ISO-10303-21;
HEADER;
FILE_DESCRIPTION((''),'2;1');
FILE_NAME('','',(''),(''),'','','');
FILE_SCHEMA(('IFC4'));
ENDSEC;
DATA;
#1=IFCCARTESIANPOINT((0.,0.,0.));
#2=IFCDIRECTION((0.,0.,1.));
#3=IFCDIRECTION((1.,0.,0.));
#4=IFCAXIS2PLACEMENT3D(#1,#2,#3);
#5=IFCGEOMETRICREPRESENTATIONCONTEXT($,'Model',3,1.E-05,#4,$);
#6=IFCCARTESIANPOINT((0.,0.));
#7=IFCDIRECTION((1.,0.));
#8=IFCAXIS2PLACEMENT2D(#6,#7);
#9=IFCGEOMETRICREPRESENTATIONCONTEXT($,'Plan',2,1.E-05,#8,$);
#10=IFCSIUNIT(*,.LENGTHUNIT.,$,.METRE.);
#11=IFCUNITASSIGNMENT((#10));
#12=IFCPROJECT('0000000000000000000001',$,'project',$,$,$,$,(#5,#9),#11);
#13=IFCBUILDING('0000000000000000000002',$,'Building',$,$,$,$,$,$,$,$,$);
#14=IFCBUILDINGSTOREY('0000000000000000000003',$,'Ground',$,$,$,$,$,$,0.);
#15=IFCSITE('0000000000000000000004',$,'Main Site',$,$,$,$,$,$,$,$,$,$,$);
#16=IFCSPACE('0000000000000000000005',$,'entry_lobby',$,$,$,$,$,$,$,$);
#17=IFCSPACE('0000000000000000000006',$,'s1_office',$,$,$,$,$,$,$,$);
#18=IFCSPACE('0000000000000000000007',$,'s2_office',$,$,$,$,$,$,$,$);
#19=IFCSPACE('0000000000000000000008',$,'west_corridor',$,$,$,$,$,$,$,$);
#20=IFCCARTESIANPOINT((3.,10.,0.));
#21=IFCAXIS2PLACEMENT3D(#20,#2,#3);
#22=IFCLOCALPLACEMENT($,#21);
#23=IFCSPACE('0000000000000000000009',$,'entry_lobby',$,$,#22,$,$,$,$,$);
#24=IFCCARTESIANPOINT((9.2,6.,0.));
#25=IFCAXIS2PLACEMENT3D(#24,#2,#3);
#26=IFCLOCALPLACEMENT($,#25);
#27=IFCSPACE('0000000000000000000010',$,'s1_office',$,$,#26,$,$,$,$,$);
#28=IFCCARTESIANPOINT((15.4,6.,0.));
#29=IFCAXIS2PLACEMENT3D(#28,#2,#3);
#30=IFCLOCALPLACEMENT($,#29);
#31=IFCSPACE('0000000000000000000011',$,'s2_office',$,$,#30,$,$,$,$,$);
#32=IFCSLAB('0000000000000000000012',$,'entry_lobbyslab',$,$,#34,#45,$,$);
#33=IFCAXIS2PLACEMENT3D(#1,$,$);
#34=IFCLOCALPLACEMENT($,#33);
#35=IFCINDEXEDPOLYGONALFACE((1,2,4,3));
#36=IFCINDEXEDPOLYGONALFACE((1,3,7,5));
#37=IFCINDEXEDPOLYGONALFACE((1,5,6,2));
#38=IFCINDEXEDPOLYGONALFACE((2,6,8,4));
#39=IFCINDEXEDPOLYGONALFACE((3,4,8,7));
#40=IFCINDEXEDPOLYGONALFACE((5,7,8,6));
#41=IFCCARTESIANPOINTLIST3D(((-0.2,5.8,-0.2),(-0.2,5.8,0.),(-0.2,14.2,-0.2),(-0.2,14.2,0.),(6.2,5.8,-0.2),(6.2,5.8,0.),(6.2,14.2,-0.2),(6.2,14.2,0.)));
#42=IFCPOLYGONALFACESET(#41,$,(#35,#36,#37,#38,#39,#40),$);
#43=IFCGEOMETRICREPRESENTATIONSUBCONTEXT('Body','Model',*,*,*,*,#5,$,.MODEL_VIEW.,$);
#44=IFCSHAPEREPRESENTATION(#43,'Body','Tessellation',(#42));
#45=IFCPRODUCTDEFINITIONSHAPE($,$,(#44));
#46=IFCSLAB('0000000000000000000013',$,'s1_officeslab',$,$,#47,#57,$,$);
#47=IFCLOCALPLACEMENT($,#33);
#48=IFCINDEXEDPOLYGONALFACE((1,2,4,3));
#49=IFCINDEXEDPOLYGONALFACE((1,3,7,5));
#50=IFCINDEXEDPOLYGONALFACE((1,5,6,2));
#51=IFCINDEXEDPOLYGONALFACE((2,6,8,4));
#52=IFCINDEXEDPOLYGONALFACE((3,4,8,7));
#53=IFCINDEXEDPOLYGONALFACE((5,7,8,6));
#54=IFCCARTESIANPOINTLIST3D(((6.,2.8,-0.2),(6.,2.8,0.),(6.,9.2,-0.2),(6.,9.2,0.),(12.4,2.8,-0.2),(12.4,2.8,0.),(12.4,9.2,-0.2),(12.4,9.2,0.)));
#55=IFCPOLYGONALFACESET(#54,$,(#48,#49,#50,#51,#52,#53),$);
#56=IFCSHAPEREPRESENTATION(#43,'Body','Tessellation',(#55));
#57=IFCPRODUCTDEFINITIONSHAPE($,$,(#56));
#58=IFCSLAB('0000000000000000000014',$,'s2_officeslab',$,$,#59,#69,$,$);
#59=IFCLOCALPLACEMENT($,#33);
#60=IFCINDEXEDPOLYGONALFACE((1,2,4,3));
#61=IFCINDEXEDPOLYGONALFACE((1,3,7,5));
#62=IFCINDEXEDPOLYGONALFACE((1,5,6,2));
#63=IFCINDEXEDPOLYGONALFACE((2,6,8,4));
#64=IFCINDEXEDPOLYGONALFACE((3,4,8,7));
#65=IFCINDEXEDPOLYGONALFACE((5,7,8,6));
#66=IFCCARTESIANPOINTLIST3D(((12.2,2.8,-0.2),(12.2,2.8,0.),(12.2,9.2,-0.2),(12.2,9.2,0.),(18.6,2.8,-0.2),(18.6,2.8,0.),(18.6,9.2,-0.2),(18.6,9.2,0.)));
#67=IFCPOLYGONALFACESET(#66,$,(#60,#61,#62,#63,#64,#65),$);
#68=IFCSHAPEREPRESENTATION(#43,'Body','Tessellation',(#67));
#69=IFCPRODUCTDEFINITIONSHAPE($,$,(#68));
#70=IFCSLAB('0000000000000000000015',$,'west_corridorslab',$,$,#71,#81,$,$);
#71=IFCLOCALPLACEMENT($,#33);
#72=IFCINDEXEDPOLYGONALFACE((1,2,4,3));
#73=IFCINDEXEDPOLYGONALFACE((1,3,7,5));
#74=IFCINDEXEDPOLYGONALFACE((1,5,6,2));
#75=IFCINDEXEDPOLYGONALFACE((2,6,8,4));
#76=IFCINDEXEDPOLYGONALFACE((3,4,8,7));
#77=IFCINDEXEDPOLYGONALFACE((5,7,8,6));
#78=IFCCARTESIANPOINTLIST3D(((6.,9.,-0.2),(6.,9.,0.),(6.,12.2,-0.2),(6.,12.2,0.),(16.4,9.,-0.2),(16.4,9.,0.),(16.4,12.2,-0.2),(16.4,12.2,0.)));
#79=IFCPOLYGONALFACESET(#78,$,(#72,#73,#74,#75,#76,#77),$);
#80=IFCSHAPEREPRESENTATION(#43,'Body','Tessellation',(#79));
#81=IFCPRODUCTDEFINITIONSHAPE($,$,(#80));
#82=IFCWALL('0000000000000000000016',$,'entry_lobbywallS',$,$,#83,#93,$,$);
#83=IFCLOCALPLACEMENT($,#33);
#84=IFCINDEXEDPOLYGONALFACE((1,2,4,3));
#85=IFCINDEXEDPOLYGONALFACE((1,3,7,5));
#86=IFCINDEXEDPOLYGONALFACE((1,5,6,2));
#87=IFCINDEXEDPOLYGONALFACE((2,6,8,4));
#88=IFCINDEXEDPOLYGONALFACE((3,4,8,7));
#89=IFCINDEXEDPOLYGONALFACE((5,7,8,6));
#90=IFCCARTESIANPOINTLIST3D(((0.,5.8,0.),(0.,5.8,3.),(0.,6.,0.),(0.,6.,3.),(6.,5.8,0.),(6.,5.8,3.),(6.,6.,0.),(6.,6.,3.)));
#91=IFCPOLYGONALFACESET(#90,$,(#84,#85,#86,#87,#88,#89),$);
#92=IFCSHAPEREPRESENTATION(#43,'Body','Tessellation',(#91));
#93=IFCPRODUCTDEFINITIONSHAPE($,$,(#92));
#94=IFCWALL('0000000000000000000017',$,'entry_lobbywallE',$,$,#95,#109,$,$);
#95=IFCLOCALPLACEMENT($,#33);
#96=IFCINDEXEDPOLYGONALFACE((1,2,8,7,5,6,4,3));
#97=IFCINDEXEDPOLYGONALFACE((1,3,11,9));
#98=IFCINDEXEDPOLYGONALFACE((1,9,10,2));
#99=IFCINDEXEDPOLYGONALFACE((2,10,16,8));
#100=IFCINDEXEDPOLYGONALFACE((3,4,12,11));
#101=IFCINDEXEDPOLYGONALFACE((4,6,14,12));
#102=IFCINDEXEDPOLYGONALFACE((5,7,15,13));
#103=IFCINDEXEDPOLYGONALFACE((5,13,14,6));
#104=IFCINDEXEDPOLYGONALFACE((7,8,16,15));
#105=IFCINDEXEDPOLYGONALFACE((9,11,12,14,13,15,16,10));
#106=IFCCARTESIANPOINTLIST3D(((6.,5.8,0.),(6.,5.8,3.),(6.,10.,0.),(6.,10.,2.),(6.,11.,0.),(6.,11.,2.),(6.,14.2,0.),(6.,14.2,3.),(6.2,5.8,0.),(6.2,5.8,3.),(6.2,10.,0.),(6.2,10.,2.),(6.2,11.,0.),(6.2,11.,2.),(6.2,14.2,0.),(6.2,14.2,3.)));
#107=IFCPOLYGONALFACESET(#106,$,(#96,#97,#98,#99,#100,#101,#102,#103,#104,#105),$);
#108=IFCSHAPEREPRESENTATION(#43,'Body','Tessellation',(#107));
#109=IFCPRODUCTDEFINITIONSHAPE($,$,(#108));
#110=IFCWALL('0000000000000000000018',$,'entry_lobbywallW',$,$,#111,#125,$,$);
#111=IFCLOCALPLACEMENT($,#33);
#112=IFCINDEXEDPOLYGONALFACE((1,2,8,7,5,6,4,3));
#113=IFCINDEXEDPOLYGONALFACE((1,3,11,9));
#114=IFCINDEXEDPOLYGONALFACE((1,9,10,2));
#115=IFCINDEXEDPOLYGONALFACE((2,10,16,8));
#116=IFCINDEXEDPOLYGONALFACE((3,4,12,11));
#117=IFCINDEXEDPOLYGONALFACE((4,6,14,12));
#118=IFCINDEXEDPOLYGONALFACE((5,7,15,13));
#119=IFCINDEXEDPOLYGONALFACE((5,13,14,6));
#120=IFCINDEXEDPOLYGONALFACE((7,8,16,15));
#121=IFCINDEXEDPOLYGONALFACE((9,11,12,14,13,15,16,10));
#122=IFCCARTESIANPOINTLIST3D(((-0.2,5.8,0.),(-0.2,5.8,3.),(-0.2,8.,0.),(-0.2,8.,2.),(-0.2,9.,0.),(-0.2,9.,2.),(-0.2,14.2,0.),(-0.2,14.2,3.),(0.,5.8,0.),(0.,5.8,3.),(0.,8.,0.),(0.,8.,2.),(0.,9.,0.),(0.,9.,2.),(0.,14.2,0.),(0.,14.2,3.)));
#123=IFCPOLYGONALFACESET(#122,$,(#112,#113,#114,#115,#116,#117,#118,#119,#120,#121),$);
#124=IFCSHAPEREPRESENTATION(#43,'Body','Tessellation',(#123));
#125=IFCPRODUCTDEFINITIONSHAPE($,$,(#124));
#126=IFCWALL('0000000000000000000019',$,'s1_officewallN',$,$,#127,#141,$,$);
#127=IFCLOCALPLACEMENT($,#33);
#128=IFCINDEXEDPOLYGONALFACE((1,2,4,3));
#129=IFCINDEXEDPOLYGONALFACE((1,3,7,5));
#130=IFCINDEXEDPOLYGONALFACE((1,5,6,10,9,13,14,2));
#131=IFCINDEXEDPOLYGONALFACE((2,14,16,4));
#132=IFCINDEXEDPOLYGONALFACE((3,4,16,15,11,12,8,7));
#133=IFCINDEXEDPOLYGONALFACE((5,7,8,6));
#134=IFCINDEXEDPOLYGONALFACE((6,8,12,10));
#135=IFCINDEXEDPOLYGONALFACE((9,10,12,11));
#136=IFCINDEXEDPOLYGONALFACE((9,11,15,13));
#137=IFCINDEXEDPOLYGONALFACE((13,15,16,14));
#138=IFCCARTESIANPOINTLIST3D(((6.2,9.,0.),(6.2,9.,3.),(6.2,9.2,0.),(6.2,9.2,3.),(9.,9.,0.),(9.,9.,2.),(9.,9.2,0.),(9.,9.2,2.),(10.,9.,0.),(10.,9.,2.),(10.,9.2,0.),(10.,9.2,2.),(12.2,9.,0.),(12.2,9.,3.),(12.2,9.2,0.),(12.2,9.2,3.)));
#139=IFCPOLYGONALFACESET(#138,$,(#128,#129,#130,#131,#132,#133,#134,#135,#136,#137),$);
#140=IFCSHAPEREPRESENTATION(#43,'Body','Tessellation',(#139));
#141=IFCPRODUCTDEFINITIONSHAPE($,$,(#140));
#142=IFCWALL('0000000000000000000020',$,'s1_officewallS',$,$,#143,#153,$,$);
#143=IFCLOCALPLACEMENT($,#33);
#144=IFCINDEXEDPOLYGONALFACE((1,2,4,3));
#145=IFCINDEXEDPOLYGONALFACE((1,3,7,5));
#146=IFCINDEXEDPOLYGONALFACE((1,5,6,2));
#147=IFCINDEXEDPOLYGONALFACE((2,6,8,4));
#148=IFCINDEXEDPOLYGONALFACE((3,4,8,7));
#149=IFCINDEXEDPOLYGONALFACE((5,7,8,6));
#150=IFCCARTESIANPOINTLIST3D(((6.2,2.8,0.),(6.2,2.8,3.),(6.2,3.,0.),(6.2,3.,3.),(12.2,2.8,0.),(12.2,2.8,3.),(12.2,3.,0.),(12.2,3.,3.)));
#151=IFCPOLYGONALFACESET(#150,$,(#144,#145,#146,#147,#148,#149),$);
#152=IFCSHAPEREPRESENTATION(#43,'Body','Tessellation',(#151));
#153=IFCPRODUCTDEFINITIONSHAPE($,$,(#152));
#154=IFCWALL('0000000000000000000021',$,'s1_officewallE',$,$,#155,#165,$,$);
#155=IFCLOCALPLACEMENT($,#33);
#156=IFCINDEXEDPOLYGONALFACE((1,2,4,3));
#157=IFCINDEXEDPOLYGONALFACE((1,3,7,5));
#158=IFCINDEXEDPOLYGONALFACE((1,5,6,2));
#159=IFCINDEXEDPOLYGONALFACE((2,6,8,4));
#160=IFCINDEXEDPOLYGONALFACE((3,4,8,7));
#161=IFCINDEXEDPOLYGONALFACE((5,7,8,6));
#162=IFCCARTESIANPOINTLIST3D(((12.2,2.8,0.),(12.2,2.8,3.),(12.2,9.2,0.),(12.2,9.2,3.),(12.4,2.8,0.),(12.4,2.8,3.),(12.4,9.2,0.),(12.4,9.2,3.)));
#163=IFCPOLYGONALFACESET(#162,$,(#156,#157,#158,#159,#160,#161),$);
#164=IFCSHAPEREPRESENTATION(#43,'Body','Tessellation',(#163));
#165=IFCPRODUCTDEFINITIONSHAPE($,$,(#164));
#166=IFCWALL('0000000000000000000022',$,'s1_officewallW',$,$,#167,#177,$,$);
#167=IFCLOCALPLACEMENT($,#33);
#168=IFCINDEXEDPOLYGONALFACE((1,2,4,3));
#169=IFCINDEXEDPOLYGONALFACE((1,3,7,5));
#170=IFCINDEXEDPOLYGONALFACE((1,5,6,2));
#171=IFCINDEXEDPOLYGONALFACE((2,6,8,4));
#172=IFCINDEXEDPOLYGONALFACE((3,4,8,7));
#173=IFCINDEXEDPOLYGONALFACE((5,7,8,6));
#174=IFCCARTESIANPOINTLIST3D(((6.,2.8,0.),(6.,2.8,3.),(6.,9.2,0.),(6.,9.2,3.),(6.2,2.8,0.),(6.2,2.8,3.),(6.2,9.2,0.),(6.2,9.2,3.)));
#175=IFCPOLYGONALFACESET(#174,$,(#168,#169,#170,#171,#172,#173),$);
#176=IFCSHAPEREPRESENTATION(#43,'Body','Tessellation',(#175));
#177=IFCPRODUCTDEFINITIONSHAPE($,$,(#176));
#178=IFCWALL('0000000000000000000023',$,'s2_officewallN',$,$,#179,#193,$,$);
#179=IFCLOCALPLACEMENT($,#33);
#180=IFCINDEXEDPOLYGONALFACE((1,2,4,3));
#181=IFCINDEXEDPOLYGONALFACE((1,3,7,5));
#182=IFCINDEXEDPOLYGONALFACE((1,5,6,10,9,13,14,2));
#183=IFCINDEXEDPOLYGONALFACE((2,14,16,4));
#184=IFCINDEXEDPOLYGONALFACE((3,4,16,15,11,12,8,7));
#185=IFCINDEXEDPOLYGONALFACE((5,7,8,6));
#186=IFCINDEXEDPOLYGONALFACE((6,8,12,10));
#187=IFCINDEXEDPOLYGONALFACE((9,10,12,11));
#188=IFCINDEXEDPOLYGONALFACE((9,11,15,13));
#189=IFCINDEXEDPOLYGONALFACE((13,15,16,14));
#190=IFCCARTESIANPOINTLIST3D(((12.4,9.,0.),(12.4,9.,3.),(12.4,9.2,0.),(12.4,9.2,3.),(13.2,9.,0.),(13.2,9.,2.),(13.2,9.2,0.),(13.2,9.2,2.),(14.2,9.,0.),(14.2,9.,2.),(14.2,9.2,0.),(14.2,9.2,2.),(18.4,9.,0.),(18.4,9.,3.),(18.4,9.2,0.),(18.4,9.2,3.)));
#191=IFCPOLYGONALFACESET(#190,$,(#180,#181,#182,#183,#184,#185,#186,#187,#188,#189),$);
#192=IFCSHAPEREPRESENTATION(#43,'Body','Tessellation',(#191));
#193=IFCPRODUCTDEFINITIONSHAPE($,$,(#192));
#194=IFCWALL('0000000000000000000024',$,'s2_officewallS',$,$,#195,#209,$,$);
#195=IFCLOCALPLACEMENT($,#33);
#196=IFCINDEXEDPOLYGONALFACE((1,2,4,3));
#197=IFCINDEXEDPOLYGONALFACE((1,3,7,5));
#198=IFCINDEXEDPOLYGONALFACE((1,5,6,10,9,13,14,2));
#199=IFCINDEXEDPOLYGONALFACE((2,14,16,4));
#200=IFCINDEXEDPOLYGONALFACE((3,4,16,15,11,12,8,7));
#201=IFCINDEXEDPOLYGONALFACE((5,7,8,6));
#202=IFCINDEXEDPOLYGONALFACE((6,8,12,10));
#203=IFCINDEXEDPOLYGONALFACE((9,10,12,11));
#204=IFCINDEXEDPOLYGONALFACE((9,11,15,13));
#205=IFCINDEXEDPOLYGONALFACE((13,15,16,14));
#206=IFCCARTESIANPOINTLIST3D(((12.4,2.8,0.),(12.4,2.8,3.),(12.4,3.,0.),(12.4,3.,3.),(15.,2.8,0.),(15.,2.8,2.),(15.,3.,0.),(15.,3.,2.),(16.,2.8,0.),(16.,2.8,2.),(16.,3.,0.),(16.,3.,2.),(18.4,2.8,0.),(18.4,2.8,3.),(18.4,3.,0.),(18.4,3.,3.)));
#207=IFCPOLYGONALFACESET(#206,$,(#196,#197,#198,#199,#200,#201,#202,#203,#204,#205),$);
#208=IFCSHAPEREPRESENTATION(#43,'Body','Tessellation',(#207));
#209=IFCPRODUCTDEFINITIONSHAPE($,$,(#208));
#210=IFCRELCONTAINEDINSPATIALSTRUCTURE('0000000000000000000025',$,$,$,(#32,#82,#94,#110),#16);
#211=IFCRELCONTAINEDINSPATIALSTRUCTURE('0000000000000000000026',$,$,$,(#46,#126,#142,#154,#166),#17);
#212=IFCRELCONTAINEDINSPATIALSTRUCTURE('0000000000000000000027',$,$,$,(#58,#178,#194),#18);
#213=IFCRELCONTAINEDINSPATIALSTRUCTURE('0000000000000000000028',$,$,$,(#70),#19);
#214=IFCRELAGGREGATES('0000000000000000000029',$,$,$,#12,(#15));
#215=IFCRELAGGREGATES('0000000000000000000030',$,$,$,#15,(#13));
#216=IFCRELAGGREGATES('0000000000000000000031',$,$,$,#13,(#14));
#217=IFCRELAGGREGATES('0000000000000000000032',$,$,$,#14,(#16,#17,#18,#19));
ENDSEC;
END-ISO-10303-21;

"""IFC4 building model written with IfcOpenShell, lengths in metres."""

from ifc_helpers import new_model, si_unit, frame, origin_with_axes, origin_2d_with_axis, place, context, subcontext, project, spatial, indexed_curve, rectangle, outline, extrude, element, save


model = new_model("IFC4")

# Units and contexts
model_context = context("Model", 3, precision=1e-05, world=origin_with_axes())
plan_context = context("Plan", 2, precision=1e-05, world=origin_2d_with_axis())
body_context = subcontext(model_context, "Body", "Model", "MODEL_VIEW")
ifc_project = project(units=[si_unit("LENGTHUNIT", "METRE")], contexts=[model_context, plan_context])

# Site, building, storey, space
site = spatial("IfcSite", under=ifc_project, Name="Main Site")
building = spatial("IfcBuilding", under=site, Name="Building")
storey = spatial("IfcBuildingStorey", under=building, Name="Ground", Elevation=0.0)
space_1 = spatial("IfcSpace", under=storey, Name="entry_lobby")

# Slab
slab_1_placement = place(None, frame((3.0, 10.0, -0.2), z_axis=(0.0, 0.0, 1.0), x_axis=(1.0, 0.0, 0.0)))
element("IfcSlab", 1, at=slab_1_placement, inside=space_1, Name="entry_lobbyslab", context=body_context, shape_type="SweptSolid", body=[
    extrude(rectangle(XDim=6.4, YDim=8.4), origin_with_axes(), (0.0, 0.0, 1.0), 0.2),
])

# Shared definitions
space_2 = spatial("IfcSpace", under=storey, Name="s1_office")

# Slab
slab_2_placement = place(None, frame((9.2, 6.0, -0.2), z_axis=(0.0, 0.0, 1.0), x_axis=(1.0, 0.0, 0.0)))
element("IfcSlab", 2, at=slab_2_placement, inside=space_2, Name="s1_officeslab", context=body_context, shape_type="SweptSolid", body=[
    extrude(rectangle(XDim=6.4, YDim=6.4), origin_with_axes(), (0.0, 0.0, 1.0), 0.2),
])

# Shared definitions
space_3 = spatial("IfcSpace", under=storey, Name="s2_office")

# Slab
slab_3_placement = place(None, frame((15.4, 6.0, -0.2), z_axis=(0.0, 0.0, 1.0), x_axis=(1.0, 0.0, 0.0)))
element("IfcSlab", 3, at=slab_3_placement, inside=space_3, Name="s2_officeslab", context=body_context, shape_type="SweptSolid", body=[
    extrude(rectangle(XDim=6.4, YDim=6.4), origin_with_axes(), (0.0, 0.0, 1.0), 0.2),
])

# Shared definitions
space_4 = spatial("IfcSpace", under=storey, Name="west_corridor")

# Slab
slab_4_placement = place(None, frame((11.2, 10.6, -0.2), z_axis=(0.0, 0.0, 1.0), x_axis=(1.0, 0.0, 0.0)))
element("IfcSlab", 4, at=slab_4_placement, inside=space_4, Name="west_corridorslab", context=body_context, shape_type="SweptSolid", body=[
    extrude(rectangle(XDim=10.4, YDim=3.2), origin_with_axes(), (0.0, 0.0, 1.0), 0.2),
])

# Walls
wall_1_placement = place(None, frame((0.0, 5.8, 0.0), z_axis=(0.0, 0.0, 1.0), x_axis=(1.0, 0.0, 0.0)))
element("IfcWall", 5, at=wall_1_placement, inside=space_1, Name="entry_lobbywallS", context=body_context, shape_type="SweptSolid", body=[
    extrude(outline(indexed_curve([(0.0, 0.0), (0.0, 0.2), (6.0, 0.2), (6.0, 0.0), (0.0, 0.0)], self_intersect=False)), origin_with_axes(), (0.0, 0.0, 1.0), 3.0),
])
wall_2_placement = place(None, frame((6.2, 5.8, 0.0), z_axis=(0.0, 0.0, 1.0), x_axis=(0.0, 1.0, 0.0)))
wall_2 = element("IfcWall", 6, at=wall_2_placement, inside=space_1, Name="entry_lobbywallE", context=body_context, shape_type="SweptSolid", body=[
    extrude(outline(indexed_curve([(0.0, 0.0), (0.0, 0.2), (8.4, 0.2), (8.4, 0.0), (0.0, 0.0)], self_intersect=False)), origin_with_axes(), (0.0, 0.0, 1.0), 3.0),
])

# Shared definitions
space_5_placement = place(None, frame((3.0, 10.0, 0.0), z_axis=(0.0, 0.0, 1.0), x_axis=(1.0, 0.0, 0.0)))
space_5 = spatial("IfcSpace", at=space_5_placement, Name="entry_lobby")

# Opening
opening_1_placement = place(wall_2_placement, frame((4.2, 0.0, 0.0), z_axis=(0.0, 0.0, 1.0), x_axis=(1.0, 0.0, 0.0)))
element("IfcOpeningElement", 7, at=opening_1_placement, inside=space_5, cuts=wall_2, context=body_context, shape_type="SweptSolid", body=[
    extrude(outline(indexed_curve([(0.0, 0.0), (0.0, 0.4), (1.0, 0.4), (1.0, 0.0), (0.0, 0.0)], self_intersect=False)), origin_with_axes(), (0.0, 0.0, 1.0), 2.0),
])

# Wall, opening
wall_3_placement = place(None, frame((0.0, 5.8, 0.0), z_axis=(0.0, 0.0, 1.0), x_axis=(0.0, 1.0, 0.0)))
wall_3 = element("IfcWall", 8, at=wall_3_placement, inside=space_1, Name="entry_lobbywallW", context=body_context, shape_type="SweptSolid", body=[
    extrude(outline(indexed_curve([(0.0, 0.0), (0.0, 0.2), (8.4, 0.2), (8.4, 0.0), (0.0, 0.0)], self_intersect=False)), origin_with_axes(), (0.0, 0.0, 1.0), 3.0),
])
opening_2_placement = place(wall_3_placement, frame((2.2, 0.0, 0.0), z_axis=(0.0, 0.0, 1.0), x_axis=(1.0, 0.0, 0.0)))
element("IfcOpeningElement", 9, at=opening_2_placement, inside=space_5, cuts=wall_3, context=body_context, shape_type="SweptSolid", body=[
    extrude(outline(indexed_curve([(0.0, 0.0), (0.0, 0.4), (1.0, 0.4), (1.0, 0.0), (0.0, 0.0)], self_intersect=False)), origin_with_axes(), (0.0, 0.0, 1.0), 2.0),
])

# Wall
wall_4_placement = place(None, frame((6.2, 9.0, 0.0), z_axis=(0.0, 0.0, 1.0), x_axis=(1.0, 0.0, 0.0)))
wall_4 = element("IfcWall", 10, at=wall_4_placement, inside=space_2, Name="s1_officewallN", context=body_context, shape_type="SweptSolid", body=[
    extrude(outline(indexed_curve([(0.0, 0.0), (0.0, 0.2), (6.0, 0.2), (6.0, 0.0), (0.0, 0.0)], self_intersect=False)), origin_with_axes(), (0.0, 0.0, 1.0), 3.0),
])

# Shared definitions
space_6_placement = place(None, frame((9.2, 6.0, 0.0), z_axis=(0.0, 0.0, 1.0), x_axis=(1.0, 0.0, 0.0)))
space_6 = spatial("IfcSpace", at=space_6_placement, Name="s1_office")

# Opening
opening_3_placement = place(wall_4_placement, frame((2.8, 0.0, 0.0), z_axis=(0.0, 0.0, 1.0), x_axis=(1.0, 0.0, 0.0)))
element("IfcOpeningElement", 11, at=opening_3_placement, inside=space_6, cuts=wall_4, context=body_context, shape_type="SweptSolid", body=[
    extrude(outline(indexed_curve([(0.0, 0.0), (0.0, 0.4), (1.0, 0.4), (1.0, 0.0), (0.0, 0.0)], self_intersect=False)), origin_with_axes(), (0.0, 0.0, 1.0), 2.0),
])

# Walls
wall_5_placement = place(None, frame((6.2, 2.8, 0.0), z_axis=(0.0, 0.0, 1.0), x_axis=(1.0, 0.0, 0.0)))
element("IfcWall", 12, at=wall_5_placement, inside=space_2, Name="s1_officewallS", context=body_context, shape_type="SweptSolid", body=[
    extrude(outline(indexed_curve([(0.0, 0.0), (0.0, 0.2), (6.0, 0.2), (6.0, 0.0), (0.0, 0.0)], self_intersect=False)), origin_with_axes(), (0.0, 0.0, 1.0), 3.0),
])
for number, where, z_axis, x_axis, name in (
    (13, (12.4, 2.8, 0.0), (0.0, 0.0, 1.0), (0.0, 1.0, 0.0), "s1_officewallE"),
    (14, (6.2, 2.8, 0.0), (0.0, 0.0, 1.0), (0.0, 1.0, 0.0), "s1_officewallW"),
):
    element("IfcWall", number, at=place(None, frame(where, z_axis=z_axis, x_axis=x_axis)), inside=space_2, Name=name, context=body_context, shape_type="SweptSolid", body=[
        extrude(outline(indexed_curve([(0.0, 0.0), (0.0, 0.2), (6.4, 0.2), (6.4, 0.0), (0.0, 0.0)], self_intersect=False)), origin_with_axes(), (0.0, 0.0, 1.0), 3.0),
    ])

# Wall
wall_6_placement = place(None, frame((12.4, 9.0, 0.0), z_axis=(0.0, 0.0, 1.0), x_axis=(1.0, 0.0, 0.0)))
wall_6 = element("IfcWall", 15, at=wall_6_placement, inside=space_3, Name="s2_officewallN", context=body_context, shape_type="SweptSolid", body=[
    extrude(outline(indexed_curve([(0.0, 0.0), (0.0, 0.2), (6.0, 0.2), (6.0, 0.0), (0.0, 0.0)], self_intersect=False)), origin_with_axes(), (0.0, 0.0, 1.0), 3.0),
])

# Shared definitions
space_7_placement = place(None, frame((15.4, 6.0, 0.0), z_axis=(0.0, 0.0, 1.0), x_axis=(1.0, 0.0, 0.0)))
space_7 = spatial("IfcSpace", at=space_7_placement, Name="s2_office")

# Opening
opening_4_placement = place(wall_6_placement, frame((0.8, 0.0, 0.0), z_axis=(0.0, 0.0, 1.0), x_axis=(1.0, 0.0, 0.0)))
element("IfcOpeningElement", 16, at=opening_4_placement, inside=space_7, cuts=wall_6, context=body_context, shape_type="SweptSolid", body=[
    extrude(outline(indexed_curve([(0.0, 0.0), (0.0, 0.4), (1.0, 0.4), (1.0, 0.0), (0.0, 0.0)], self_intersect=False)), origin_with_axes(), (0.0, 0.0, 1.0), 2.0),
])

# Wall, opening
wall_7_placement = place(None, frame((12.4, 2.8, 0.0), z_axis=(0.0, 0.0, 1.0), x_axis=(1.0, 0.0, 0.0)))
wall_7 = element("IfcWall", 17, at=wall_7_placement, inside=space_3, Name="s2_officewallS", context=body_context, shape_type="SweptSolid", body=[
    extrude(outline(indexed_curve([(0.0, 0.0), (0.0, 0.2), (6.0, 0.2), (6.0, 0.0), (0.0, 0.0)], self_intersect=False)), origin_with_axes(), (0.0, 0.0, 1.0), 3.0),
])
opening_5_placement = place(wall_7_placement, frame((2.6, 0.0, 0.0), z_axis=(0.0, 0.0, 1.0), x_axis=(1.0, 0.0, 0.0)))
element("IfcOpeningElement", 18, at=opening_5_placement, inside=space_7, cuts=wall_7, context=body_context, shape_type="SweptSolid", body=[
    extrude(outline(indexed_curve([(0.0, 0.0), (0.0, 0.4), (1.0, 0.4), (1.0, 0.0), (0.0, 0.0)], self_intersect=False)), origin_with_axes(), (0.0, 0.0, 1.0), 2.0),
])

save(model, "model.ifc")
